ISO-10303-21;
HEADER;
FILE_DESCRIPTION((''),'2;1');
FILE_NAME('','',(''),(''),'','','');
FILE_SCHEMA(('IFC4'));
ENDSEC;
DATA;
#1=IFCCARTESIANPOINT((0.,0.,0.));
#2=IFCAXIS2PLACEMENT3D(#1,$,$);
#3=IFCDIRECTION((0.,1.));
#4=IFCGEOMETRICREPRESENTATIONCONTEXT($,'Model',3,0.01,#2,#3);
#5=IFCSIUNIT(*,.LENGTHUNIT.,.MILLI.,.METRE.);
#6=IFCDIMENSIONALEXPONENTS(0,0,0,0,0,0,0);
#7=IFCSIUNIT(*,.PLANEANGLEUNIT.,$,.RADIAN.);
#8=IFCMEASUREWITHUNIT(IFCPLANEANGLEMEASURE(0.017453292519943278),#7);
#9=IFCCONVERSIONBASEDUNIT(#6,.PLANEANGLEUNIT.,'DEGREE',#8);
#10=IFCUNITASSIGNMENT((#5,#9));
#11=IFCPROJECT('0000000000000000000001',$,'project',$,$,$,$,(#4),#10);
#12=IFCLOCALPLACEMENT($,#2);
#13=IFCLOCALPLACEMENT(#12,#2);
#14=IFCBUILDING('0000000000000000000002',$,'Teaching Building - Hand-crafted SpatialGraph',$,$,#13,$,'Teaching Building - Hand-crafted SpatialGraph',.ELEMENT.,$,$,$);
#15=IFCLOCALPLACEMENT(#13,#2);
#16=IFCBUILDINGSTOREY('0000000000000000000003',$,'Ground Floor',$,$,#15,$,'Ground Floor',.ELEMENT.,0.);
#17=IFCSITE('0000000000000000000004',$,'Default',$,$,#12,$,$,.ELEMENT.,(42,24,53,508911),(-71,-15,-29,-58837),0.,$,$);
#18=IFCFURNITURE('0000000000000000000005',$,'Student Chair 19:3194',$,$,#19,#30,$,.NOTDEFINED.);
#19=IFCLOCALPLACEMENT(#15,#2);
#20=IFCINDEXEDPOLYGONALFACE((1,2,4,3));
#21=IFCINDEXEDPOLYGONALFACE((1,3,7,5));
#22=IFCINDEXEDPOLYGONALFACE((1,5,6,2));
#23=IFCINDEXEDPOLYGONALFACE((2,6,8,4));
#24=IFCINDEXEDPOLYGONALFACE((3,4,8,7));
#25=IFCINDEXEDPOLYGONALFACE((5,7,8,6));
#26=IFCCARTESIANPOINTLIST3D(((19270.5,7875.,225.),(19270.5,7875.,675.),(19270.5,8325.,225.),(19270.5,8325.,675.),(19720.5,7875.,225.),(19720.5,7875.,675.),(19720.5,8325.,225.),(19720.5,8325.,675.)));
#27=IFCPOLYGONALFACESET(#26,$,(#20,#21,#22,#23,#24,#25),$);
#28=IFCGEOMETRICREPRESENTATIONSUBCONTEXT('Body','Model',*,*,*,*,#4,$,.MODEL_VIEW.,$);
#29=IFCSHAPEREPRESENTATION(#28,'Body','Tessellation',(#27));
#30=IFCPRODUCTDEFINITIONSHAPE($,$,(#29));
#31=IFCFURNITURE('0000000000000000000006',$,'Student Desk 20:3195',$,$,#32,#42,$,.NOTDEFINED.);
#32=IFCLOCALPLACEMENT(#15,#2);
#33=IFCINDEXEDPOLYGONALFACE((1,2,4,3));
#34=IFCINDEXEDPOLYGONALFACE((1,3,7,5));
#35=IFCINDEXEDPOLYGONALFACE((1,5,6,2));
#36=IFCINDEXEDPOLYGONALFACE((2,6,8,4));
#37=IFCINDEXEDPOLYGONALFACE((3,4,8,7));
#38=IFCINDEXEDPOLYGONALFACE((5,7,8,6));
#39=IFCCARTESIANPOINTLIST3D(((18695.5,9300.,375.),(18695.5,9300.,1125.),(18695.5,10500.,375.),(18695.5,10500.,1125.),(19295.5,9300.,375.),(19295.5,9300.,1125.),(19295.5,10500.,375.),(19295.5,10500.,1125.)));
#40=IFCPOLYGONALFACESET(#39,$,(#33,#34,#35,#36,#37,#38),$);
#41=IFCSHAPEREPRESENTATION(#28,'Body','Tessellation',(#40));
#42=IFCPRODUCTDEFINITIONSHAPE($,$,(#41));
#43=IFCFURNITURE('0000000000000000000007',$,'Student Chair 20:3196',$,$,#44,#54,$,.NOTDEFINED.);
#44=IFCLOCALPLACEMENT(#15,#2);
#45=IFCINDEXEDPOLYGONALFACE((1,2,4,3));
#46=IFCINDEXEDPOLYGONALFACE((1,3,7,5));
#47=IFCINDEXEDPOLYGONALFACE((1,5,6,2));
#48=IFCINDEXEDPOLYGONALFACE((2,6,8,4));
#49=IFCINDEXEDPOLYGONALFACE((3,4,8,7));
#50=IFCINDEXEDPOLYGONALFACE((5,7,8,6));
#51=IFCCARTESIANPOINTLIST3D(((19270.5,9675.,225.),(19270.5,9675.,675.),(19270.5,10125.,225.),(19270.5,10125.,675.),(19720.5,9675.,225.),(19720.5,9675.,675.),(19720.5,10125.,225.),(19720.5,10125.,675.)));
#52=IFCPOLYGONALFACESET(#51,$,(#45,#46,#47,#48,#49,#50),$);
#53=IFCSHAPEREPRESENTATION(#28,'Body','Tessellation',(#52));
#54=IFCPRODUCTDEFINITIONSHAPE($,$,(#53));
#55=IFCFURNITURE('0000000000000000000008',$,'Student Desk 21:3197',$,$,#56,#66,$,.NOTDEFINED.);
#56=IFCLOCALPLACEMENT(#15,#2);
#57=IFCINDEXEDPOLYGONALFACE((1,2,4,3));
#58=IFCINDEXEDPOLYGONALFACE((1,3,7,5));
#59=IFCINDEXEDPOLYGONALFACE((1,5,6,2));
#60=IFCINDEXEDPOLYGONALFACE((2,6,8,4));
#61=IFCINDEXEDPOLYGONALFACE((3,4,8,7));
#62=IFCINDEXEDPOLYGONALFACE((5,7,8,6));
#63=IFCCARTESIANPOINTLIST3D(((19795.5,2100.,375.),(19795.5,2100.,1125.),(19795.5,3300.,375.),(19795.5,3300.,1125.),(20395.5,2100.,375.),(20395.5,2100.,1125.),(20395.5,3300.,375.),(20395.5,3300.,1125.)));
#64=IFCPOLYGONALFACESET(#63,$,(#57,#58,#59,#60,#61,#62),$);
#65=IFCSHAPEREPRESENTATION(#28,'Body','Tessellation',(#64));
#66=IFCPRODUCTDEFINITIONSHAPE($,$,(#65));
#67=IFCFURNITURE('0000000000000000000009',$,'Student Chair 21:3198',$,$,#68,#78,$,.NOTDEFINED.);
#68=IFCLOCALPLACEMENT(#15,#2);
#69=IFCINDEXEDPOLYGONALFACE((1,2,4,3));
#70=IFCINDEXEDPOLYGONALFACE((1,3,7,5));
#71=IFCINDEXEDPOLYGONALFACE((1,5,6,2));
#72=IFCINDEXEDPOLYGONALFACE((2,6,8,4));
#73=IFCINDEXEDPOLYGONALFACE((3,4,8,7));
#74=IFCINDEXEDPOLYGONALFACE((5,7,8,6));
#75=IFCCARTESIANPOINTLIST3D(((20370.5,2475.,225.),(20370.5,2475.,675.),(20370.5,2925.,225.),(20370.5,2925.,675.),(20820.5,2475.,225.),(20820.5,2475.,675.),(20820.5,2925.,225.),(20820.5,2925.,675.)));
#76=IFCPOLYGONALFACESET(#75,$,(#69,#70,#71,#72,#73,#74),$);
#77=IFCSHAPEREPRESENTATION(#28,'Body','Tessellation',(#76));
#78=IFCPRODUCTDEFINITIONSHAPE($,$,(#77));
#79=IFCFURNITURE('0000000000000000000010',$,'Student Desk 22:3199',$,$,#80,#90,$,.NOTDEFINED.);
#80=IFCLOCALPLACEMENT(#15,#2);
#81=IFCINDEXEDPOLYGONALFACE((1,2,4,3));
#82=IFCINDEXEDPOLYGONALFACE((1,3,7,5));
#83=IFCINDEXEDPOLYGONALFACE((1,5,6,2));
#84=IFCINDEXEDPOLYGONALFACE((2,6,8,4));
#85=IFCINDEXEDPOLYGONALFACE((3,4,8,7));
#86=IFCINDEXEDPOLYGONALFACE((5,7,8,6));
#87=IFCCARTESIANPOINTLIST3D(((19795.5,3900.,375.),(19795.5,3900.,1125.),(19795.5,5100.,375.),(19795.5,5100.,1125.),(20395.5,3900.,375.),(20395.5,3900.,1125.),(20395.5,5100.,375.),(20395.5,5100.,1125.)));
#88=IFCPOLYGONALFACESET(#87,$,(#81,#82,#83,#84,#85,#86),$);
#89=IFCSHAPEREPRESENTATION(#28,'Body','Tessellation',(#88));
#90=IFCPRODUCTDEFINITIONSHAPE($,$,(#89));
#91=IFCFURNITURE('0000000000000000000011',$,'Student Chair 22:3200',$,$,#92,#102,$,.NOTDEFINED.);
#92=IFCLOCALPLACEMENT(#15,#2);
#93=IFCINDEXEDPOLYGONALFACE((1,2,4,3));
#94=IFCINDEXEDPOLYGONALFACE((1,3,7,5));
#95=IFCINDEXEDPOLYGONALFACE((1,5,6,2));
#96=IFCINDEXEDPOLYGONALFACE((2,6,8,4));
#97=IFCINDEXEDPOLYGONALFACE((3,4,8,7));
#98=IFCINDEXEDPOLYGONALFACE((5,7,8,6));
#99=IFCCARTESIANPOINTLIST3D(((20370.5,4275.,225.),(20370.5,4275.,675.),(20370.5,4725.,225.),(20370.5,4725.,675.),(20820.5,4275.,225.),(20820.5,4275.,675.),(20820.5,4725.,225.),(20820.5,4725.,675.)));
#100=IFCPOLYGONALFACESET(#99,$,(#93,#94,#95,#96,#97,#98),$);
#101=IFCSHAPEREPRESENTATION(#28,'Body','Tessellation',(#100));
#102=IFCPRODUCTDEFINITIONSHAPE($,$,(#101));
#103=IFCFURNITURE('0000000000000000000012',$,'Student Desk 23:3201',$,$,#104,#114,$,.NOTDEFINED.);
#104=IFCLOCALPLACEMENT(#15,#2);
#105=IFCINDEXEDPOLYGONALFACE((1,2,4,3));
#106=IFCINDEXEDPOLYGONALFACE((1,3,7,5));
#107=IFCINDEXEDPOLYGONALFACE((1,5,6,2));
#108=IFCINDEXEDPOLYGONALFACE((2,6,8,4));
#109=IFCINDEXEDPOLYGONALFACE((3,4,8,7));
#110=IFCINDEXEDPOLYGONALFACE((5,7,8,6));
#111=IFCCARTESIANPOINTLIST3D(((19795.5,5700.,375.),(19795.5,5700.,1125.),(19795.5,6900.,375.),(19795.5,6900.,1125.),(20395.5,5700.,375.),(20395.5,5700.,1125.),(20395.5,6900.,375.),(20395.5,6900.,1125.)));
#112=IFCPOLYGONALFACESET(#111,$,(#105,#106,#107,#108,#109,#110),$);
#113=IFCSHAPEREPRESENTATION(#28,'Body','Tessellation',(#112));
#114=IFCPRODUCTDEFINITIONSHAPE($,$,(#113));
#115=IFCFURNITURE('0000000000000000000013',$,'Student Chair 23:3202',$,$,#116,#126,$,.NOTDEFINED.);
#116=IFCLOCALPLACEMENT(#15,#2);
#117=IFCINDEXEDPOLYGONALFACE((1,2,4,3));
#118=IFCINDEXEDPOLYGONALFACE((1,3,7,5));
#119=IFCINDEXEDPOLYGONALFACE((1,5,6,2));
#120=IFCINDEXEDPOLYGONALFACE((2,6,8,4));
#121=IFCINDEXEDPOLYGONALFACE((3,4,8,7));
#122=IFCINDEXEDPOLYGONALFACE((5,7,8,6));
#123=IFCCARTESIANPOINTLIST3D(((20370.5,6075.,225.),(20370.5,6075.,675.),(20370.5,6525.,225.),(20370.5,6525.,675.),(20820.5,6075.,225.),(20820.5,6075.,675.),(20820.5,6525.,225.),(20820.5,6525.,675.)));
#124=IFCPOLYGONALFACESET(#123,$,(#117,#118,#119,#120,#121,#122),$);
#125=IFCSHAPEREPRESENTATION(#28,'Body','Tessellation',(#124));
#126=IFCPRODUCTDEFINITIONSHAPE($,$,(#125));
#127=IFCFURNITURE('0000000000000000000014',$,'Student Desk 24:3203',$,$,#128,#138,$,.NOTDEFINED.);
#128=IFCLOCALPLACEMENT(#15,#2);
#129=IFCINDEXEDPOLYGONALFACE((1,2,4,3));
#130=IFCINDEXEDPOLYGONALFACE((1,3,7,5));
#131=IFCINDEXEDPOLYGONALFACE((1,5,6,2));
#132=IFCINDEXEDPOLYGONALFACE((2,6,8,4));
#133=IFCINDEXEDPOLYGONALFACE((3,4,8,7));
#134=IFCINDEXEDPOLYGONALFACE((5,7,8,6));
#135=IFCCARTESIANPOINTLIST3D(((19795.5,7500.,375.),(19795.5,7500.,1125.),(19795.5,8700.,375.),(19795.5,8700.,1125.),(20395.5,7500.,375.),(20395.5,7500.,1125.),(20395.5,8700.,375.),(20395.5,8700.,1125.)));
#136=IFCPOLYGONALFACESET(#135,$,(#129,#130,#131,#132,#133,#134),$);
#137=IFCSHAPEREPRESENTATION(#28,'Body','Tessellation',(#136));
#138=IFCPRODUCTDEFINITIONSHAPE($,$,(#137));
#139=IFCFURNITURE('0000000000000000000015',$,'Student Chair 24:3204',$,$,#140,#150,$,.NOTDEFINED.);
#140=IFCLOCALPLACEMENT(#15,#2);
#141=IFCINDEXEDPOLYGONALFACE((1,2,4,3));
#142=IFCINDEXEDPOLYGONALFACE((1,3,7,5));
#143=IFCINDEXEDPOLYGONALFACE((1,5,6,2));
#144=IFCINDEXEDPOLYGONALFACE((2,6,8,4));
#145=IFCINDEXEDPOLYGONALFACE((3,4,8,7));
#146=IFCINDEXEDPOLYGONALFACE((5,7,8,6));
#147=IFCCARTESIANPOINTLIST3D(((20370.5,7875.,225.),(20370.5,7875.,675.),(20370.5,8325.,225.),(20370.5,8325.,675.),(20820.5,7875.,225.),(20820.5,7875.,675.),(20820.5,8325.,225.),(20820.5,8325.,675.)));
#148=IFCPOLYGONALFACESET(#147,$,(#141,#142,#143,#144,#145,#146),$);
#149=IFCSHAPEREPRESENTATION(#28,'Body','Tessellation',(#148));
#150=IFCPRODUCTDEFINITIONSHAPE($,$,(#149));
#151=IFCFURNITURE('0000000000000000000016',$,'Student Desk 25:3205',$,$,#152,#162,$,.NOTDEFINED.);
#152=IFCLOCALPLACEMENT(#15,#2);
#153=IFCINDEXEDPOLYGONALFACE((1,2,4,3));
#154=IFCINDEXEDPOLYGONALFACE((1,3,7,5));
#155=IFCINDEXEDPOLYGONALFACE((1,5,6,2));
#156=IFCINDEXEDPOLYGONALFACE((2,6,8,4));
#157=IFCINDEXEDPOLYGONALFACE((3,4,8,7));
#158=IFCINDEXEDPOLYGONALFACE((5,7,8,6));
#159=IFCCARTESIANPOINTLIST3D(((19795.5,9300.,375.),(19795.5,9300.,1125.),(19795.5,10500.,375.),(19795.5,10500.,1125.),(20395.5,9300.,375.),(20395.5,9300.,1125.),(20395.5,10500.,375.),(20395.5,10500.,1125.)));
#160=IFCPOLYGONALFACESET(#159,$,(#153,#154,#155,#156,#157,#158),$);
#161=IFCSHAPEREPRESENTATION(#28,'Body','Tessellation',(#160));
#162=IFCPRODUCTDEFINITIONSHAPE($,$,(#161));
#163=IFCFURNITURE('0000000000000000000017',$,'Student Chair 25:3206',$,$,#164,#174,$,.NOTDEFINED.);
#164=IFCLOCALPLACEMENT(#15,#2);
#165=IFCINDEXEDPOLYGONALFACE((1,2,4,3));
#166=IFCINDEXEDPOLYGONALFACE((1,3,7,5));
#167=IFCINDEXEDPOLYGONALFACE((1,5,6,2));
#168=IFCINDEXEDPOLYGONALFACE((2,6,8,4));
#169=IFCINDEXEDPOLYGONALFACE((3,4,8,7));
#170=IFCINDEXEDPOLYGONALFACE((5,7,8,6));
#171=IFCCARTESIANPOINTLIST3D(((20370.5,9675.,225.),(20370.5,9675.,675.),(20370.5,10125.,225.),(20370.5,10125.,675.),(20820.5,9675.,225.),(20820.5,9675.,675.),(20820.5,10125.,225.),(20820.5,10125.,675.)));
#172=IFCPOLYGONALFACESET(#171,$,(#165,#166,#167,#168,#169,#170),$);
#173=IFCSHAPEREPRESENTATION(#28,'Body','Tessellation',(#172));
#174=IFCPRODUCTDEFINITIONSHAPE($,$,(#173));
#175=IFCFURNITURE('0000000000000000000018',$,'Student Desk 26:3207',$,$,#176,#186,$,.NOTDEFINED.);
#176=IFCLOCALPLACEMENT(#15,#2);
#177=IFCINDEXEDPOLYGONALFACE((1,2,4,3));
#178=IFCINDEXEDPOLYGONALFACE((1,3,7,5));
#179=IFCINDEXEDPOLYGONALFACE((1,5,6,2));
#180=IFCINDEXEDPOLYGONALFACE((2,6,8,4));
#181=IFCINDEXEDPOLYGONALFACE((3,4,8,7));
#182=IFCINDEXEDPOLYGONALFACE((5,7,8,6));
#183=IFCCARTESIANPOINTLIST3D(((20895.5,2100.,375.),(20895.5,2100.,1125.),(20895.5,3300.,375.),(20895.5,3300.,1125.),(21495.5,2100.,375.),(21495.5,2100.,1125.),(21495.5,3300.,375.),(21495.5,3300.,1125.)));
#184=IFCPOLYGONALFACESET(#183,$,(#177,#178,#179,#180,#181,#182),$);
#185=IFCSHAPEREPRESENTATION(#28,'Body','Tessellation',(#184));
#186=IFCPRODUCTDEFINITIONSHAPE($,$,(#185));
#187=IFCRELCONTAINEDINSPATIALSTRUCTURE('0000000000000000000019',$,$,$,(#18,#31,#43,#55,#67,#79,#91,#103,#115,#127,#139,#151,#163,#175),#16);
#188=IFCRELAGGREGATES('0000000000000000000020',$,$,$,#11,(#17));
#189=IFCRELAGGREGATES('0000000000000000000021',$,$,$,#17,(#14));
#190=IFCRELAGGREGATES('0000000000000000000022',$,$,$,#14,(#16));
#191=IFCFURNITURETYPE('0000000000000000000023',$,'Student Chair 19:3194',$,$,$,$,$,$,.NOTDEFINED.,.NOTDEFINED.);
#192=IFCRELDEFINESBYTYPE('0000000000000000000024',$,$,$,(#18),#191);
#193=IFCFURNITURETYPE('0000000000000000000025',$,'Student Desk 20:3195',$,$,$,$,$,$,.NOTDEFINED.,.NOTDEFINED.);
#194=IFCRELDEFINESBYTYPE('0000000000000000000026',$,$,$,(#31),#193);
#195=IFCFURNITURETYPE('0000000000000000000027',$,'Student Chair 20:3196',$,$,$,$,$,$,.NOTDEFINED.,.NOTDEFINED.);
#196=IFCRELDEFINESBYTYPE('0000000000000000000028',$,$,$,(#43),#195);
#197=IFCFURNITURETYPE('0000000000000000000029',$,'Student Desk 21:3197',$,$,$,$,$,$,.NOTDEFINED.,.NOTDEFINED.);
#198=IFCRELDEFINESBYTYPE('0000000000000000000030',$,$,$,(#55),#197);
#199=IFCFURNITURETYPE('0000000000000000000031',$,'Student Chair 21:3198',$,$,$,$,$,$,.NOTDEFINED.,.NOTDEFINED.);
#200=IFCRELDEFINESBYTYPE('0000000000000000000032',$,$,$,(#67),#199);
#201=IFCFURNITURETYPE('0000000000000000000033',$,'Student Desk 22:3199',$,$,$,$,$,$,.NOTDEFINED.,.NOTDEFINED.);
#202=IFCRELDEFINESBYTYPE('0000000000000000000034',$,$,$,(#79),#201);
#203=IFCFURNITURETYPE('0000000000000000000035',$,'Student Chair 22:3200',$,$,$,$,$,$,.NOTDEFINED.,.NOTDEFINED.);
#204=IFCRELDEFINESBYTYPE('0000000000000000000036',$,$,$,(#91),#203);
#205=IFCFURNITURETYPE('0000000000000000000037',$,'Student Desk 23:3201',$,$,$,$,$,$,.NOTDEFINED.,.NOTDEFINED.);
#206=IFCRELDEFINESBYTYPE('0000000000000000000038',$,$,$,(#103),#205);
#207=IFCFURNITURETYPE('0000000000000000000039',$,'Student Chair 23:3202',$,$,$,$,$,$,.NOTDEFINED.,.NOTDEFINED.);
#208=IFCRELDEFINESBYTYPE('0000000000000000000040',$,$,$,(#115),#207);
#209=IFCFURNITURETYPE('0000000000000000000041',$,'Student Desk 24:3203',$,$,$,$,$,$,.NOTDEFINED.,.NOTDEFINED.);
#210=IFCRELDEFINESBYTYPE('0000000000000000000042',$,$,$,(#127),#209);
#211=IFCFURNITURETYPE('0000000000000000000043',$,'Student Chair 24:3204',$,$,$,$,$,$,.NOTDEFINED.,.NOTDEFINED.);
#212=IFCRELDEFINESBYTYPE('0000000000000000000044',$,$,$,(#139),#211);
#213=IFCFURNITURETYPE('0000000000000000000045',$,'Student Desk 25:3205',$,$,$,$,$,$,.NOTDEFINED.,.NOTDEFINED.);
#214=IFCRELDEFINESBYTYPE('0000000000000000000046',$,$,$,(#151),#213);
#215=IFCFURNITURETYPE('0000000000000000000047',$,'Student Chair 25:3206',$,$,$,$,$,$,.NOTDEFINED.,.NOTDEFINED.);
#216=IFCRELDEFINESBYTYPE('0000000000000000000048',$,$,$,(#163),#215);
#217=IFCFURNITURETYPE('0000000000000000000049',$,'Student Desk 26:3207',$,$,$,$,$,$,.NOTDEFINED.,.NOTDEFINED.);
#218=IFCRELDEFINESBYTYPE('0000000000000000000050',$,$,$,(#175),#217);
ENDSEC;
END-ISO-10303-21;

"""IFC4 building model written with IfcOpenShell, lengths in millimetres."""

from ifc_helpers import new_model, entity, si_unit, converted_unit, direction, frame, frame_2d, origin, origin_2d_with_axis, place, context, subcontext, project, spatial, rectangle, extrude, type_object, element, save


model = new_model("IFC4")

# Units and contexts
model_context = context("Model", 3, precision=0.01, world=origin(), true_north=direction((0.0, 1.0)))
body_context = subcontext(model_context, "Body", "Model", "MODEL_VIEW")
ifc_project = project(units=[si_unit("LENGTHUNIT", "METRE", prefix="MILLI"), converted_unit("PLANEANGLEUNIT", "DEGREE", entity("IfcPlaneAngleMeasure", 0.017453292519943278), si_unit("PLANEANGLEUNIT", "RADIAN"), dimensions=[0, 0, 0, 0, 0, 0, 0])], contexts=[model_context])

# Site, building, storey
site_placement = place(None, origin())
site = spatial("IfcSite", under=ifc_project, at=site_placement, Name="Default", CompositionType="ELEMENT", RefLatitude=(42, 24, 53, 508911), RefLongitude=(-71, -15, -29, -58837), RefElevation=0.0)
building_placement = place(site_placement, origin())
building = spatial("IfcBuilding", under=site, at=building_placement, Name="Teaching Building - Hand-crafted SpatialGraph", LongName="Teaching Building - Hand-crafted SpatialGraph", CompositionType="ELEMENT")
storey_placement = place(building_placement, origin())
storey = spatial("IfcBuildingStorey", under=building, at=storey_placement, Name="Ground Floor", LongName="Ground Floor", CompositionType="ELEMENT", Elevation=0.0)

# Furniture
furniture_type_1 = type_object("IfcFurnitureType", Name="Student Chair 19:3194", PredefinedType="NOTDEFINED")
furniture_1_placement = place(storey_placement, origin())
element("IfcFurniture", 1, at=furniture_1_placement, inside=storey, type_object=furniture_type_1, Name="Student Chair 19:3194", PredefinedType="NOTDEFINED", context=body_context, shape_type="SweptSolid", body=[
    extrude(rectangle(XDim=450.0, YDim=450.0, at=origin_2d_with_axis()), frame((19495.5, 8100.0, 225.0)), (0.0, 0.0, 1.0), 450.0),
])
furniture_type_2 = type_object("IfcFurnitureType", Name="Student Desk 20:3195", PredefinedType="NOTDEFINED")
furniture_2_placement = place(storey_placement, origin())
element("IfcFurniture", 2, at=furniture_2_placement, inside=storey, type_object=furniture_type_2, Name="Student Desk 20:3195", PredefinedType="NOTDEFINED", context=body_context, shape_type="SweptSolid", body=[
    extrude(rectangle(XDim=1200.0, YDim=600.0, at=origin_2d_with_axis()), frame((18995.5, 9900.0, 375.0), z_axis=(0.0, 0.0, 1.0), x_axis=(0.0, 1.0, 0.0)), (0.0, 0.0, 1.0), 750.0),
])
furniture_type_3 = type_object("IfcFurnitureType", Name="Student Chair 20:3196", PredefinedType="NOTDEFINED")
furniture_3_placement = place(storey_placement, origin())
element("IfcFurniture", 3, at=furniture_3_placement, inside=storey, type_object=furniture_type_3, Name="Student Chair 20:3196", PredefinedType="NOTDEFINED", context=body_context, shape_type="SweptSolid", body=[
    extrude(rectangle(XDim=450.0, YDim=450.0, at=frame_2d((0.0, 0.0), x_axis=(1.0, 0.0))), frame((19495.5, 9900.0, 225.0)), (0.0, 0.0, 1.0), 450.0),
])
furniture_type_4 = type_object("IfcFurnitureType", Name="Student Desk 21:3197", PredefinedType="NOTDEFINED")
furniture_4_placement = place(storey_placement, origin())
element("IfcFurniture", 4, at=furniture_4_placement, inside=storey, type_object=furniture_type_4, Name="Student Desk 21:3197", PredefinedType="NOTDEFINED", context=body_context, shape_type="SweptSolid", body=[
    extrude(rectangle(XDim=1200.0, YDim=600.0, at=origin_2d_with_axis()), frame((20095.5, 2700.0, 375.0), z_axis=(0.0, 0.0, 1.0), x_axis=(0.0, 1.0, 0.0)), (0.0, 0.0, 1.0), 750.0),
])
furniture_type_5 = type_object("IfcFurnitureType", Name="Student Chair 21:3198", PredefinedType="NOTDEFINED")
furniture_5_placement = place(storey_placement, origin())
element("IfcFurniture", 5, at=furniture_5_placement, inside=storey, type_object=furniture_type_5, Name="Student Chair 21:3198", PredefinedType="NOTDEFINED", context=body_context, shape_type="SweptSolid", body=[
    extrude(rectangle(XDim=450.0, YDim=450.0, at=origin_2d_with_axis()), frame((20595.5, 2700.0, 225.0)), (0.0, 0.0, 1.0), 450.0),
])
furniture_type_6 = type_object("IfcFurnitureType", Name="Student Desk 22:3199", PredefinedType="NOTDEFINED")
furniture_6_placement = place(storey_placement, origin())
element("IfcFurniture", 6, at=furniture_6_placement, inside=storey, type_object=furniture_type_6, Name="Student Desk 22:3199", PredefinedType="NOTDEFINED", context=body_context, shape_type="SweptSolid", body=[
    extrude(rectangle(XDim=1200.0, YDim=600.0, at=frame_2d((0.0, 0.0), x_axis=(1.0, 0.0))), frame((20095.5, 4500.0, 375.0), z_axis=(0.0, 0.0, 1.0), x_axis=(0.0, 1.0, 0.0)), (0.0, 0.0, 1.0), 750.0),
])
furniture_type_7 = type_object("IfcFurnitureType", Name="Student Chair 22:3200", PredefinedType="NOTDEFINED")
furniture_7_placement = place(storey_placement, origin())
element("IfcFurniture", 7, at=furniture_7_placement, inside=storey, type_object=furniture_type_7, Name="Student Chair 22:3200", PredefinedType="NOTDEFINED", context=body_context, shape_type="SweptSolid", body=[
    extrude(rectangle(XDim=450.0, YDim=450.0, at=origin_2d_with_axis()), frame((20595.5, 4500.0, 225.0)), (0.0, 0.0, 1.0), 450.0),
])
furniture_type_8 = type_object("IfcFurnitureType", Name="Student Desk 23:3201", PredefinedType="NOTDEFINED")
furniture_8_placement = place(storey_placement, origin())
element("IfcFurniture", 8, at=furniture_8_placement, inside=storey, type_object=furniture_type_8, Name="Student Desk 23:3201", PredefinedType="NOTDEFINED", context=body_context, shape_type="SweptSolid", body=[
    extrude(rectangle(XDim=1200.0, YDim=600.0, at=origin_2d_with_axis()), frame((20095.5, 6300.0, 375.0), z_axis=(0.0, 0.0, 1.0), x_axis=(0.0, 1.0, 0.0)), (0.0, 0.0, 1.0), 750.0),
])
furniture_type_9 = type_object("IfcFurnitureType", Name="Student Chair 23:3202", PredefinedType="NOTDEFINED")
furniture_9_placement = place(storey_placement, origin())
element("IfcFurniture", 9, at=furniture_9_placement, inside=storey, type_object=furniture_type_9, Name="Student Chair 23:3202", PredefinedType="NOTDEFINED", context=body_context, shape_type="SweptSolid", body=[
    extrude(rectangle(XDim=450.0, YDim=450.0, at=origin_2d_with_axis()), frame((20595.5, 6300.0, 225.0)), (0.0, 0.0, 1.0), 450.0),
])
furniture_type_10 = type_object("IfcFurnitureType", Name="Student Desk 24:3203", PredefinedType="NOTDEFINED")
furniture_10_placement = place(storey_placement, origin())
element("IfcFurniture", 10, at=furniture_10_placement, inside=storey, type_object=furniture_type_10, Name="Student Desk 24:3203", PredefinedType="NOTDEFINED", context=body_context, shape_type="SweptSolid", body=[
    extrude(rectangle(XDim=1200.0, YDim=600.0, at=origin_2d_with_axis()), frame((20095.5, 8100.0, 375.0), z_axis=(0.0, 0.0, 1.0), x_axis=(0.0, 1.0, 0.0)), (0.0, 0.0, 1.0), 750.0),
])
furniture_type_11 = type_object("IfcFurnitureType", Name="Student Chair 24:3204", PredefinedType="NOTDEFINED")
furniture_11_placement = place(storey_placement, origin())
element("IfcFurniture", 11, at=furniture_11_placement, inside=storey, type_object=furniture_type_11, Name="Student Chair 24:3204", PredefinedType="NOTDEFINED", context=body_context, shape_type="SweptSolid", body=[
    extrude(rectangle(XDim=450.0, YDim=450.0, at=origin_2d_with_axis()), frame((20595.5, 8100.0, 225.0)), (0.0, 0.0, 1.0), 450.0),
])
furniture_type_12 = type_object("IfcFurnitureType", Name="Student Desk 25:3205", PredefinedType="NOTDEFINED")
furniture_12_placement = place(storey_placement, origin())
element("IfcFurniture", 12, at=furniture_12_placement, inside=storey, type_object=furniture_type_12, Name="Student Desk 25:3205", PredefinedType="NOTDEFINED", context=body_context, shape_type="SweptSolid", body=[
    extrude(rectangle(XDim=1200.0, YDim=600.0, at=origin_2d_with_axis()), frame((20095.5, 9900.0, 375.0), z_axis=(0.0, 0.0, 1.0), x_axis=(0.0, 1.0, 0.0)), (0.0, 0.0, 1.0), 750.0),
])
furniture_type_13 = type_object("IfcFurnitureType", Name="Student Chair 25:3206", PredefinedType="NOTDEFINED")
furniture_13_placement = place(storey_placement, origin())
element("IfcFurniture", 13, at=furniture_13_placement, inside=storey, type_object=furniture_type_13, Name="Student Chair 25:3206", PredefinedType="NOTDEFINED", context=body_context, shape_type="SweptSolid", body=[
    extrude(rectangle(XDim=450.0, YDim=450.0, at=frame_2d((0.0, 0.0), x_axis=(1.0, 0.0))), frame((20595.5, 9900.0, 225.0)), (0.0, 0.0, 1.0), 450.0),
])
furniture_type_14 = type_object("IfcFurnitureType", Name="Student Desk 26:3207", PredefinedType="NOTDEFINED")
furniture_14_placement = place(storey_placement, origin())
element("IfcFurniture", 14, at=furniture_14_placement, inside=storey, type_object=furniture_type_14, Name="Student Desk 26:3207", PredefinedType="NOTDEFINED", context=body_context, shape_type="SweptSolid", body=[
    extrude(rectangle(XDim=1200.0, YDim=600.0, at=origin_2d_with_axis()), frame((21195.5, 2700.0, 375.0), z_axis=(0.0, 0.0, 1.0), x_axis=(0.0, 1.0, 0.0)), (0.0, 0.0, 1.0), 750.0),
])

save(model, "model.ifc")
